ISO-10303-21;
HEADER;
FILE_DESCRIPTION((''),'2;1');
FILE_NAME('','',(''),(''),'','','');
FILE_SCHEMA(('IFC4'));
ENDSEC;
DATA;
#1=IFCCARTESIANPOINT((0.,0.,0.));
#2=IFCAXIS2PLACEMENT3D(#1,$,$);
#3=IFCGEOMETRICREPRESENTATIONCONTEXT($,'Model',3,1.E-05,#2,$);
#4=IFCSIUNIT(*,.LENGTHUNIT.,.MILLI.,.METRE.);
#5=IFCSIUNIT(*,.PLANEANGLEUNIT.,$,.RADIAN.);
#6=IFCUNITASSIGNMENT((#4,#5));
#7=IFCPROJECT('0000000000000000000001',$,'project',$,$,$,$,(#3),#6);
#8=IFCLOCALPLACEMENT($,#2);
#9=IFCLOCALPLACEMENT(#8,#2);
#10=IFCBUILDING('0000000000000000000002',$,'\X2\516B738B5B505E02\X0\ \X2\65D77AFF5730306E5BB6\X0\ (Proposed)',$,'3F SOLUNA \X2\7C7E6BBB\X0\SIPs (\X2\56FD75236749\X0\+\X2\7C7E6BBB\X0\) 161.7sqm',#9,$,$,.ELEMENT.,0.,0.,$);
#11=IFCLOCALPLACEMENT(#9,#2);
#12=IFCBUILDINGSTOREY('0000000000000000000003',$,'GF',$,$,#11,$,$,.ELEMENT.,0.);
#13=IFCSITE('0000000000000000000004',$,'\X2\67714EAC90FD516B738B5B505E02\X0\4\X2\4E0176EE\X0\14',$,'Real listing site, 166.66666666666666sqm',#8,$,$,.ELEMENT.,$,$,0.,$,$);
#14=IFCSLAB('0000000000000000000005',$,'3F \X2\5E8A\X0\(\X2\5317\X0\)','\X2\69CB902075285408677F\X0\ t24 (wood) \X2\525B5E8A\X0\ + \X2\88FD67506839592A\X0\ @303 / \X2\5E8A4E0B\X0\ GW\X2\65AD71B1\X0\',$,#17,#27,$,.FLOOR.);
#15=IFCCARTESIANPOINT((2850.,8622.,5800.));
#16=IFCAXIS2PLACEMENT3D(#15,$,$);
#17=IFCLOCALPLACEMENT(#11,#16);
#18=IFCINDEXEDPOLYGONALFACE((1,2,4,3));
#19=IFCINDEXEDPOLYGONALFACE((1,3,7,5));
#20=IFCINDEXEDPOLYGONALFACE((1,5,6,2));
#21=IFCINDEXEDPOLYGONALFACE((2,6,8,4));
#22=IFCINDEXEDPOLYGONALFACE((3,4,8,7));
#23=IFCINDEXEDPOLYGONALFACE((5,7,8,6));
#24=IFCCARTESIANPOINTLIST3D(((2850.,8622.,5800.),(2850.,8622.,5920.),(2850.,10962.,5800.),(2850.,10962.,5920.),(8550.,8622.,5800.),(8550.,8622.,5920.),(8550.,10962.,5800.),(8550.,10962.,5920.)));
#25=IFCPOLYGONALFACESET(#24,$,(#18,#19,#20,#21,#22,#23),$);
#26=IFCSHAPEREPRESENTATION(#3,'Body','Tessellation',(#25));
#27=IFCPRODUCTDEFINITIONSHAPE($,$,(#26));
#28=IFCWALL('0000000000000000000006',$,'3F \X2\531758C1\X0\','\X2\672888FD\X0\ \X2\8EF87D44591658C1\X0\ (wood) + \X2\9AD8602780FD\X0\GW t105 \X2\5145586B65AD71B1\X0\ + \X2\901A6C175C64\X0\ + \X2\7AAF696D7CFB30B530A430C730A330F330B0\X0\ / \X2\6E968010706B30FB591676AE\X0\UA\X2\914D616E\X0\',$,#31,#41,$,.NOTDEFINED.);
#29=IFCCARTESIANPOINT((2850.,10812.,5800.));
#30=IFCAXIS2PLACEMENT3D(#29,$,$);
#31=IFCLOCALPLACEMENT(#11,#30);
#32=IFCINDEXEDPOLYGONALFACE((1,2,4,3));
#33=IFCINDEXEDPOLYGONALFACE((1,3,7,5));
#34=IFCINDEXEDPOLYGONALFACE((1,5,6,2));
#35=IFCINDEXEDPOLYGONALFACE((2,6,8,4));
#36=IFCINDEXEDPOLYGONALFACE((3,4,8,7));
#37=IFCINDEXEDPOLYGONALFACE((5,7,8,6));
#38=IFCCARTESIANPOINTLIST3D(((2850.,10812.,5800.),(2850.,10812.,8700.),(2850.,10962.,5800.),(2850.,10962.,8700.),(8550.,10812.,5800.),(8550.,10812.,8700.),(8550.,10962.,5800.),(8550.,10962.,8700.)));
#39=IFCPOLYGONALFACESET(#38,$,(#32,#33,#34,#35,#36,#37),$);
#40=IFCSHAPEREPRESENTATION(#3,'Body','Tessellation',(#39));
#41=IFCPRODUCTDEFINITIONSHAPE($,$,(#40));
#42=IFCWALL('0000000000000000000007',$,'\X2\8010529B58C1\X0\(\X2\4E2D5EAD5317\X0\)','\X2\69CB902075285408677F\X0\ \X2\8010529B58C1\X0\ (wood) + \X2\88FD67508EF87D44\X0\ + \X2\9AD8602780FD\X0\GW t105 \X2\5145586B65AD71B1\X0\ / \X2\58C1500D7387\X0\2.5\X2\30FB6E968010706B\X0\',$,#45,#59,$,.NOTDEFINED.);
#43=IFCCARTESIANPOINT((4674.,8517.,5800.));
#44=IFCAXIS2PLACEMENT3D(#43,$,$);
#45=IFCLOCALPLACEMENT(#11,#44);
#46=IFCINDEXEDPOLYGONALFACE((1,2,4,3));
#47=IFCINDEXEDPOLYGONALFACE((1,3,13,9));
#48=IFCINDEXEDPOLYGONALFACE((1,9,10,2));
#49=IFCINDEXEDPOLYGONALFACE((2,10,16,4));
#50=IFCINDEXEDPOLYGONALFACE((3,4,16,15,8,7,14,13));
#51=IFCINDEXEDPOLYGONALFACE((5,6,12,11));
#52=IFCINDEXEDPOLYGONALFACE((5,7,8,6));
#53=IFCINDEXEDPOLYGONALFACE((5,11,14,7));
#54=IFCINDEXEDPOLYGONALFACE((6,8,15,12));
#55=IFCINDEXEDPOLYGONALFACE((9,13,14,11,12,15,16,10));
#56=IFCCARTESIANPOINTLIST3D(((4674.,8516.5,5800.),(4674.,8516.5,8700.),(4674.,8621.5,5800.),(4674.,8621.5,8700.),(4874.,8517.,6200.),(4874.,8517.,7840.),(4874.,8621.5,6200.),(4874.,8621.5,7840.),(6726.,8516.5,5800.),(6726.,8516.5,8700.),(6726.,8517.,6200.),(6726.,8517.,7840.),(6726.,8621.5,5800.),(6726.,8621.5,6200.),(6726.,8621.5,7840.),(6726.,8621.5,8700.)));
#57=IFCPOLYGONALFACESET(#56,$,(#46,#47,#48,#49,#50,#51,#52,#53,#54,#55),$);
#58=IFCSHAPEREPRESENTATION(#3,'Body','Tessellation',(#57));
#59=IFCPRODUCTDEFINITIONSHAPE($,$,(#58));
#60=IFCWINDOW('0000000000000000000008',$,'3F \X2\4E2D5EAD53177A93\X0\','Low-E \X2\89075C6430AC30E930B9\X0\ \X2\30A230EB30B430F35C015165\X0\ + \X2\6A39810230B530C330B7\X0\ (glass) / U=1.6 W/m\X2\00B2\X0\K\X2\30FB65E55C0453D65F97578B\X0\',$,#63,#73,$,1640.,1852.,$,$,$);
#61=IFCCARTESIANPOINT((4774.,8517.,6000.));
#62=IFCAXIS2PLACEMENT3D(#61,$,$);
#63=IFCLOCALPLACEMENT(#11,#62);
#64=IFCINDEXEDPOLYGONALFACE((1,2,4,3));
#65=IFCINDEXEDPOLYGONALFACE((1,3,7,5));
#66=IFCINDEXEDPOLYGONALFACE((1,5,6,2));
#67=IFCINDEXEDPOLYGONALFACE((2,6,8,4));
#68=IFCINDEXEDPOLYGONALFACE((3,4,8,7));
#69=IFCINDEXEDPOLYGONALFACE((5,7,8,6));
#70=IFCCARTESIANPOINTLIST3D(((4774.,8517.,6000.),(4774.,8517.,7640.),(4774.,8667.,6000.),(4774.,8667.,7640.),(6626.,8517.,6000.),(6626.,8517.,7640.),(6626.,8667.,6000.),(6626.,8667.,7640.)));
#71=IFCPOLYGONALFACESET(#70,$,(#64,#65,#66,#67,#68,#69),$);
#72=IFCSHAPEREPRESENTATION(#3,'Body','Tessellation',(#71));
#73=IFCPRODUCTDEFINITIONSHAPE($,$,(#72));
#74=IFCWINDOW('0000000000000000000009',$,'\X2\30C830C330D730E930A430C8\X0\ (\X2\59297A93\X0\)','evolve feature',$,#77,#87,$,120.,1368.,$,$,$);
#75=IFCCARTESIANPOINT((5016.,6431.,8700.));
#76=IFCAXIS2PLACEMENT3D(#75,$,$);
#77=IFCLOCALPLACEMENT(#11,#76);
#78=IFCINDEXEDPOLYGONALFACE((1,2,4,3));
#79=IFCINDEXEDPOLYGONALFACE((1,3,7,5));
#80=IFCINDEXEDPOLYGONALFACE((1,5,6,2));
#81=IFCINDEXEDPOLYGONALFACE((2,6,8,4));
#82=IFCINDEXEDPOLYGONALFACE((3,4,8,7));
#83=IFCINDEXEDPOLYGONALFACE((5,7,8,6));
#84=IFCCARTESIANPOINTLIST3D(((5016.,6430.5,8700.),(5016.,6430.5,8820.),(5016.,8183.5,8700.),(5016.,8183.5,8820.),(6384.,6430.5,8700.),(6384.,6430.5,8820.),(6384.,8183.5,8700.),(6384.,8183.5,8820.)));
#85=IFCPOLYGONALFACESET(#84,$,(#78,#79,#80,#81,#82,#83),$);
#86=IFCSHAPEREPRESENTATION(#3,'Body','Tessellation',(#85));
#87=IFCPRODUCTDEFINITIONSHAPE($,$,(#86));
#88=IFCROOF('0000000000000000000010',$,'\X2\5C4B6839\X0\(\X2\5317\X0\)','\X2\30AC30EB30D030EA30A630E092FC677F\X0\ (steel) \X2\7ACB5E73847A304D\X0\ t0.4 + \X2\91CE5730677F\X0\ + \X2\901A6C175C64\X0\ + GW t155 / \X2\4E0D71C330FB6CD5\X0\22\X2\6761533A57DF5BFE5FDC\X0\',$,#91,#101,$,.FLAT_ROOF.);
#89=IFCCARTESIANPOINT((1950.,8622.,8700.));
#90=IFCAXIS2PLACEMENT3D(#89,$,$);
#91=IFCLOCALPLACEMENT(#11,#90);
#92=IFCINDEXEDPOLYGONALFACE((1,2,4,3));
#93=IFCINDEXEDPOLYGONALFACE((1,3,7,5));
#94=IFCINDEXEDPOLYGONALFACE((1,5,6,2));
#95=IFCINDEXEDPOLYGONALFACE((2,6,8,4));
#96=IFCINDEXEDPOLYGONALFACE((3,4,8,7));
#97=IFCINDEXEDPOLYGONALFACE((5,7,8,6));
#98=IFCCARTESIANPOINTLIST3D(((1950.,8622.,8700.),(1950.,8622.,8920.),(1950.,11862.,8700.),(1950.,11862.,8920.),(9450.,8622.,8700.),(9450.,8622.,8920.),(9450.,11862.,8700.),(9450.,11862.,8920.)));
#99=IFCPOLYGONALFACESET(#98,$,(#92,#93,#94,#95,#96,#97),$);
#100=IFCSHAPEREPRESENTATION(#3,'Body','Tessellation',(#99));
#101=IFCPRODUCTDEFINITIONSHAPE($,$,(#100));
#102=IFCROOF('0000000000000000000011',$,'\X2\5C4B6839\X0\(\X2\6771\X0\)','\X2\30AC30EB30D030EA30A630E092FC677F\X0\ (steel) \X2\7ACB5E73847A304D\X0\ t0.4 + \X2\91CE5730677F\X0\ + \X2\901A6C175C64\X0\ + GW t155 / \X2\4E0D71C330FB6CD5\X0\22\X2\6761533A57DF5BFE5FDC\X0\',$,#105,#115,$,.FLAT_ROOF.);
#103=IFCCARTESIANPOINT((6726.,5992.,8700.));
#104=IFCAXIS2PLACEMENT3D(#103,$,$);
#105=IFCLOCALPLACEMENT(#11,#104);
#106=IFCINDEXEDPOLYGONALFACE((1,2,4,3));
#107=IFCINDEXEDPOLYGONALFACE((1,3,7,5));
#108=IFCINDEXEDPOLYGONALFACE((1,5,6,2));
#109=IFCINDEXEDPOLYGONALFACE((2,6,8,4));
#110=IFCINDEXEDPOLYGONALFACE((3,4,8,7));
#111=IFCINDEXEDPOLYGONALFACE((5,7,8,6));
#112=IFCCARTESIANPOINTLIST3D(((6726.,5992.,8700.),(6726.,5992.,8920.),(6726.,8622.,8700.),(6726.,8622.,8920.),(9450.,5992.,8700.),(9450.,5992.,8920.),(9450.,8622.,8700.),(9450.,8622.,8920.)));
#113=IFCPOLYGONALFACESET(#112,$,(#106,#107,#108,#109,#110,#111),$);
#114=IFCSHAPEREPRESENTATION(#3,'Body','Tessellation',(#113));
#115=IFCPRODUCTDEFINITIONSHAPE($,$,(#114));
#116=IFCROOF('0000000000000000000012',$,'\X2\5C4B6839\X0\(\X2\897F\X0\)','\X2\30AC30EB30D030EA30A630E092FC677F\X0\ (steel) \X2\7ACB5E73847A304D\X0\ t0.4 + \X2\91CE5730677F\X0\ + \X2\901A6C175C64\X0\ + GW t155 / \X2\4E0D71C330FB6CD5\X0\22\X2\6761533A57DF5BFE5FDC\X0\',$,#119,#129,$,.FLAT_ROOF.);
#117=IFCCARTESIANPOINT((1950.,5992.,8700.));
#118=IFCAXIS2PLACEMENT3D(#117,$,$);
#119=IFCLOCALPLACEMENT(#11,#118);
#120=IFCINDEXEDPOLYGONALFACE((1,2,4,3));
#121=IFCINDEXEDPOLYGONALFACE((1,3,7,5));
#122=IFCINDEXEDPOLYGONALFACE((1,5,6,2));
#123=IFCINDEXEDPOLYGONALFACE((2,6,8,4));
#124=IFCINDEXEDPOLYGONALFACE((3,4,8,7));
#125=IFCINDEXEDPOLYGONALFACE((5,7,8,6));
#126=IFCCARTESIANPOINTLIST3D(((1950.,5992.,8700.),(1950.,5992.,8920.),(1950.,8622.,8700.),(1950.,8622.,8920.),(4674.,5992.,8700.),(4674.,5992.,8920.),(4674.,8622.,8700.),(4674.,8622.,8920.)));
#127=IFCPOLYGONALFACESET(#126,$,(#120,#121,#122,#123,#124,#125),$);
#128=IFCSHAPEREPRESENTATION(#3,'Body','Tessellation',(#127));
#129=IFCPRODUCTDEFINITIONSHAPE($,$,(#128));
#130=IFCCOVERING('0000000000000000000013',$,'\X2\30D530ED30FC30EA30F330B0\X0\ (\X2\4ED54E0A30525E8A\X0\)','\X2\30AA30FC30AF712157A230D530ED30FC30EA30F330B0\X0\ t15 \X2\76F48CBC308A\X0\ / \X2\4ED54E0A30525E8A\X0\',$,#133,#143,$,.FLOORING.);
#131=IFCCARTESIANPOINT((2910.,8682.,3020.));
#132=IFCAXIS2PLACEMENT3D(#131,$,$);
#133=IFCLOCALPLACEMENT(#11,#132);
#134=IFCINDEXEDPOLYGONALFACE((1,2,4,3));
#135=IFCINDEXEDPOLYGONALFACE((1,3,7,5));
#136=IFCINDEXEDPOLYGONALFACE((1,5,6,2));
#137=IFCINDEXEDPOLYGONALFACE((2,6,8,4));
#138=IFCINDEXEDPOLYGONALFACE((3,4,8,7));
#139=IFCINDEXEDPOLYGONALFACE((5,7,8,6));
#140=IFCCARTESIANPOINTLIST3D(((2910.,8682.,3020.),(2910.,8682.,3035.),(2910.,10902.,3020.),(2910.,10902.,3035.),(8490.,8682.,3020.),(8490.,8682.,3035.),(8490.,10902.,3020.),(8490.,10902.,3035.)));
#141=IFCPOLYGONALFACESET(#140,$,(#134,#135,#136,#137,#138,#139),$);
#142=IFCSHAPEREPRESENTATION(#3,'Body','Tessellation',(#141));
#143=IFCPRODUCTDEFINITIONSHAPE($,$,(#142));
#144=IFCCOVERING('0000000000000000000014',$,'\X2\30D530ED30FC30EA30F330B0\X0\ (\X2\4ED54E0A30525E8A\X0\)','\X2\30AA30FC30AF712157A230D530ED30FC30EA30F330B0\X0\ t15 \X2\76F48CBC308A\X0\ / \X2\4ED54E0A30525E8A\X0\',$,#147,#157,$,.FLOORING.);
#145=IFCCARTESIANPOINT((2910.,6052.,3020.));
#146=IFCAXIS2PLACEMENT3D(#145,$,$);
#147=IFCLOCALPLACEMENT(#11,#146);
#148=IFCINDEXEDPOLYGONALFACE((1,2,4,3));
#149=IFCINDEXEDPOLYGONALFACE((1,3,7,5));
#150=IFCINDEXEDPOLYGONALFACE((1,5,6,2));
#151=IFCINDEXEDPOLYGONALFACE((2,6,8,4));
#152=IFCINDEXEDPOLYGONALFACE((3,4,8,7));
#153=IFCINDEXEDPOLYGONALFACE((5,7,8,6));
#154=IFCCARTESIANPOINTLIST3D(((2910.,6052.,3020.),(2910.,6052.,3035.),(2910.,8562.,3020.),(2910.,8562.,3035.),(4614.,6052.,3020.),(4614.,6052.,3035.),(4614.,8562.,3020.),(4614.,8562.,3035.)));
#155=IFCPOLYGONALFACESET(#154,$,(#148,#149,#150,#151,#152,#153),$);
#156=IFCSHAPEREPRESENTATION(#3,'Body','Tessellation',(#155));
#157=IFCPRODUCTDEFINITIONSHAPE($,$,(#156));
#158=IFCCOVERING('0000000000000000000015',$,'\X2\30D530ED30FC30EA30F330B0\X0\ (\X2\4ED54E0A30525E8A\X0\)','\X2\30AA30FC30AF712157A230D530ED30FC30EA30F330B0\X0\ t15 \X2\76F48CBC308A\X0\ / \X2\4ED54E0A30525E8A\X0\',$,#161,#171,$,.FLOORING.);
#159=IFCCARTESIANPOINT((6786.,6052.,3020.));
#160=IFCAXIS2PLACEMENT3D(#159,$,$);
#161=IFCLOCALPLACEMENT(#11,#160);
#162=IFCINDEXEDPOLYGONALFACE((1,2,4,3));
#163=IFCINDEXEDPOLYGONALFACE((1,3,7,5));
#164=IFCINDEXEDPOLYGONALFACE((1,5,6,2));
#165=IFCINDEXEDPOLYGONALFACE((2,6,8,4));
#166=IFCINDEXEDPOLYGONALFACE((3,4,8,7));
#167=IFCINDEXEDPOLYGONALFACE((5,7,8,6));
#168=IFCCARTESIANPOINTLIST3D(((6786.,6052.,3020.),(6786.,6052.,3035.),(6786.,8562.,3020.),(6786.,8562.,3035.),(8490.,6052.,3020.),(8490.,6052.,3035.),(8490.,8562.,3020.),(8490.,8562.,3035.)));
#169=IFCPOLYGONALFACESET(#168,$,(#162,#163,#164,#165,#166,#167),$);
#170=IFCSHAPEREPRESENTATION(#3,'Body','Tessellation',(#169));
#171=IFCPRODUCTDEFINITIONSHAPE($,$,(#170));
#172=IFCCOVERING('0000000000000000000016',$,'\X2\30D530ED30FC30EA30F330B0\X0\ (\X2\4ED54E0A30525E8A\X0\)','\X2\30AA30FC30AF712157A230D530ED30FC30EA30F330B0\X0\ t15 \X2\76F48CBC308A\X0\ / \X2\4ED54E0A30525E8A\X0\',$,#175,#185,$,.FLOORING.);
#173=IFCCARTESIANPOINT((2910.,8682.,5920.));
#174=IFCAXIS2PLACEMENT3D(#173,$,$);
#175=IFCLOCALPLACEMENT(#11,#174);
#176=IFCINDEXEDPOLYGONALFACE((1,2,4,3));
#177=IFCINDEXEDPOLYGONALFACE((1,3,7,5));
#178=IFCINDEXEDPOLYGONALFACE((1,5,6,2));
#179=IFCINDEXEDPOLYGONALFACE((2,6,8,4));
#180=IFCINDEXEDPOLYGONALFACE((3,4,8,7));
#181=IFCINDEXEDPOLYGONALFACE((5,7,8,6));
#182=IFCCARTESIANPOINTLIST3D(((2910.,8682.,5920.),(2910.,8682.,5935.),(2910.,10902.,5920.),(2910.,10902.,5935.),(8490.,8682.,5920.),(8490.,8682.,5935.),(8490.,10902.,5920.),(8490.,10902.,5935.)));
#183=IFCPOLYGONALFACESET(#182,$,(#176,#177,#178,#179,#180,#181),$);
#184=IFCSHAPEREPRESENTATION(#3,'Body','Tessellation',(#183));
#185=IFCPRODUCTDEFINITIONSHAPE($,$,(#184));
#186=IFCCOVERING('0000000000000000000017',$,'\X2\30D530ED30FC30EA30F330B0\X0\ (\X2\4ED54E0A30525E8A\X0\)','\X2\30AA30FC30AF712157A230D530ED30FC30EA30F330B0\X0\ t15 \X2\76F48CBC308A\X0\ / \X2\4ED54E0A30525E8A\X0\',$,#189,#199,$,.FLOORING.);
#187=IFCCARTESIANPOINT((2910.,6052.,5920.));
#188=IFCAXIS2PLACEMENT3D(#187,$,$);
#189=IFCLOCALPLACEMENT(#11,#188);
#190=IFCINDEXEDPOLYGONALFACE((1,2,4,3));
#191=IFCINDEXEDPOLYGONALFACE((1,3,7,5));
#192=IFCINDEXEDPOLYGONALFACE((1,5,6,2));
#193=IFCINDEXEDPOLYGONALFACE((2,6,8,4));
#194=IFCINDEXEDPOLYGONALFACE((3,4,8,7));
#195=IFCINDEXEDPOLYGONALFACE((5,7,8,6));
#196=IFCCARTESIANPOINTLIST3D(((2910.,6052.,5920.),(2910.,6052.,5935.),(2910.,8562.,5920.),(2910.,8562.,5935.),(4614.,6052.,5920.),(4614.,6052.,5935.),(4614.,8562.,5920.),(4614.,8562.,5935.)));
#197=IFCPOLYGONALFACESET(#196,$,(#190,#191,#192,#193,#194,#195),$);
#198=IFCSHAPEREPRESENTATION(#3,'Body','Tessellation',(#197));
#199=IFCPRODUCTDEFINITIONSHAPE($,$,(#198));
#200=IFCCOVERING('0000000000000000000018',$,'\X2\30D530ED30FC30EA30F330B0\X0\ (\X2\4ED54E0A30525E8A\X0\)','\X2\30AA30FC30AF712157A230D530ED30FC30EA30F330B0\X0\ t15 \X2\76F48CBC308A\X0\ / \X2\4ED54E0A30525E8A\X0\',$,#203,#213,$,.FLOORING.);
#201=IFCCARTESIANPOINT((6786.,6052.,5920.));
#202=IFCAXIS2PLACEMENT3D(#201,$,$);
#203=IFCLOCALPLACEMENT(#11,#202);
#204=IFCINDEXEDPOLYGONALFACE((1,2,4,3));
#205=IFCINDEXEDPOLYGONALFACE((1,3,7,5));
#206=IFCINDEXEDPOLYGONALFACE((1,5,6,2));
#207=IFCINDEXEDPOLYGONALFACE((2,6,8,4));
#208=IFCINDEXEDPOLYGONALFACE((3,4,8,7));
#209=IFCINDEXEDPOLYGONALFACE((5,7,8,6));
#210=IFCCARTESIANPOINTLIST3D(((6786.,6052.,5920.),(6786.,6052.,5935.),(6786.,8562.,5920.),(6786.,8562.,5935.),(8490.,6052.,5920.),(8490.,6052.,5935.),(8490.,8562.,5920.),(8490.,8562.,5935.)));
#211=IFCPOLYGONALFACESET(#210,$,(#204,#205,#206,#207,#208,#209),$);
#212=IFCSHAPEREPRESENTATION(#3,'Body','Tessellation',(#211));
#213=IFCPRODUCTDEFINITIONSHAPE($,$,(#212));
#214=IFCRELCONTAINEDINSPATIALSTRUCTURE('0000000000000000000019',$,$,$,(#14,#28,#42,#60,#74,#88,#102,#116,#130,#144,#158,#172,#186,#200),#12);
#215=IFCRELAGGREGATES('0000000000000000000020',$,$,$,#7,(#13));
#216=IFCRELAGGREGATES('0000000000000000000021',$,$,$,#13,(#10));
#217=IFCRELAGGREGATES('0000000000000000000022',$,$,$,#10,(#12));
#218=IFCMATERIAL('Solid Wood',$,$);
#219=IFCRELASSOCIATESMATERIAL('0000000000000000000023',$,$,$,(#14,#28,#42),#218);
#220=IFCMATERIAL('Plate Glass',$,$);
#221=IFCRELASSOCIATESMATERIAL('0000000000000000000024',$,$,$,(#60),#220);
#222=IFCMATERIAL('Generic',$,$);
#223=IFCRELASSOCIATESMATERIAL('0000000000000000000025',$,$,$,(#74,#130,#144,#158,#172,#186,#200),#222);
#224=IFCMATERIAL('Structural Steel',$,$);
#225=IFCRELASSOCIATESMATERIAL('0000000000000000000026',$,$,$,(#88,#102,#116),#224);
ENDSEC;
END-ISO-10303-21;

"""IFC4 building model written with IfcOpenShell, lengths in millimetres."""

from ifc_helpers import new_model, si_unit, frame, frame_2d, origin, place, context, project, spatial, rectangle, extrude, material, element, fill, save


model = new_model("IFC4")

# Units and contexts
model_context = context("Model", 3, precision=1e-05, world=origin())
ifc_project = project(units=[si_unit("LENGTHUNIT", "METRE", prefix="MILLI"), si_unit("PLANEANGLEUNIT", "RADIAN")], contexts=[model_context])

# Site, building, storey
site_placement = place(None, origin())
site = spatial("IfcSite", under=ifc_project, at=site_placement, Name="東京都八王子市4丁目14", ObjectType="Real listing site, 166.66666666666666sqm", CompositionType="ELEMENT", RefElevation=0.0)
building_placement = place(site_placement, origin())
building = spatial("IfcBuilding", under=site, at=building_placement, Name="八王子市 旗竿地の家 (Proposed)", ObjectType="3F SOLUNA 籾殻SIPs (国産杉+籾殻) 161.7sqm", CompositionType="ELEMENT", ElevationOfRefHeight=0.0, ElevationOfTerrain=0.0)
storey_placement = place(building_placement, origin())
storey = spatial("IfcBuildingStorey", under=building, at=storey_placement, Name="GF", CompositionType="ELEMENT", Elevation=0.0)

# Slab
ifc_material_1 = material(Name="Solid Wood")
slab_placement = place(storey_placement, frame((2850.0, 8622.0, 5800.0)))
element("IfcSlab", 1, at=slab_placement, inside=storey, material=ifc_material_1, Name="3F 床(北)", Description="構造用合板 t24 (wood) 剛床 + 製材根太 @303 / 床下 GW断熱", PredefinedType="FLOOR", context=model_context, shape_type="SweptSolid", body=[
    extrude(rectangle(XDim=5700.0, YDim=2340.0, at=frame_2d((2850.0, 1170.0))), frame((2850.0, 8622.0, 5800.0)), (0.0, 0.0, 1.0), 120.0),
])

# Wall
wall_1_placement = place(storey_placement, frame((2850.0, 10812.0, 5800.0)))
element("IfcWall", 2, at=wall_1_placement, inside=storey, material=ifc_material_1, Name="3F 北壁", Description="木製 軸組外壁 (wood) + 高性能GW t105 充填断熱 + 通気層 + 窯業系サイディング / 準耐火・外皮UA配慮", PredefinedType="NOTDEFINED", context=model_context, shape_type="SweptSolid", body=[
    extrude(rectangle(XDim=5700.0, YDim=150.0, at=frame_2d((2850.0, 75.0))), frame((2850.0, 10812.0, 5800.0)), (0.0, 0.0, 1.0), 2900.0),
])

# Wall, opening, window
wall_2_placement = place(storey_placement, frame((4674.0, 8517.0, 5800.0)))
wall_2 = element("IfcWall", 3, at=wall_2_placement, inside=storey, material=ifc_material_1, Name="耐力壁(中庭北)", Description="構造用合板 耐力壁 (wood) + 製材軸組 + 高性能GW t105 充填断熱 / 壁倍率2.5・準耐火", PredefinedType="NOTDEFINED", context=model_context, shape_type="SweptSolid", body=[
    extrude(rectangle(XDim=2052.0, YDim=105.0, at=frame_2d((1026.0, 52.0))), frame((4674.0, 8517.0, 5800.0)), (0.0, 0.0, 1.0), 2900.0),
])
opening_placement = place(storey_placement, frame((4774.0, 8517.0, 6000.0)))
opening = element("IfcOpeningElement", 4, at=opening_placement, cuts=wall_2, PredefinedType="NOTDEFINED", context=model_context, shape_type="SweptSolid", body=[
    extrude(rectangle(XDim=1852.0, YDim=150.0, at=frame_2d((926.0, 75.0))), frame((4774.0, 8517.0, 6000.0)), (0.0, 0.0, 1.0), 1640.0),
])
ifc_material_2 = material(Name="Plate Glass")
window_1_placement = place(storey_placement, frame((4774.0, 8517.0, 6000.0)))
window_1 = element("IfcWindow", 5, at=window_1_placement, inside=storey, material=ifc_material_2, Name="3F 中庭北窓", Description="Low-E 複層ガラス アルゴン封入 + 樹脂サッシ (glass) / U=1.6 W/m²K・日射取得型", OverallHeight=1640.0, OverallWidth=1852.0, context=model_context, shape_type="SweptSolid", body=[
    extrude(rectangle(XDim=1852.0, YDim=150.0, at=frame_2d((926.0, 75.0))), frame((4774.0, 8517.0, 6000.0)), (0.0, 0.0, 1.0), 1640.0),
])
fill(opening, window_1)

# Window
ifc_material_3 = material(Name="Generic")
window_2_placement = place(storey_placement, frame((5016.0, 6431.0, 8700.0)))
element("IfcWindow", 6, at=window_2_placement, inside=storey, material=ifc_material_3, Name="トップライト (天窓)", Description="evolve feature", OverallHeight=120.0, OverallWidth=1368.0, context=model_context, shape_type="SweptSolid", body=[
    extrude(rectangle(XDim=1368.0, YDim=1753.0, at=frame_2d((684.0, 876.0))), frame((5016.0, 6431.0, 8700.0)), (0.0, 0.0, 1.0), 120.0),
])

# Roofs
ifc_material_4 = material(Name="Structural Steel")
roof_1_placement = place(storey_placement, frame((1950.0, 8622.0, 8700.0)))
element("IfcRoof", 7, at=roof_1_placement, inside=storey, material=ifc_material_4, Name="屋根(北)", Description="ガルバリウム鋼板 (steel) 立平葺き t0.4 + 野地板 + 通気層 + GW t155 / 不燃・法22条区域対応", PredefinedType="FLAT_ROOF", context=model_context, shape_type="SweptSolid", body=[
    extrude(rectangle(XDim=7500.0, YDim=3240.0, at=frame_2d((3750.0, 1620.0))), frame((1950.0, 8622.0, 8700.0)), (0.0, 0.0, 1.0), 220.0),
])
roof_2_placement = place(storey_placement, frame((6726.0, 5992.0, 8700.0)))
element("IfcRoof", 8, at=roof_2_placement, inside=storey, material=ifc_material_4, Name="屋根(東)", Description="ガルバリウム鋼板 (steel) 立平葺き t0.4 + 野地板 + 通気層 + GW t155 / 不燃・法22条区域対応", PredefinedType="FLAT_ROOF", context=model_context, shape_type="SweptSolid", body=[
    extrude(rectangle(XDim=2724.0, YDim=2630.0, at=frame_2d((1362.0, 1315.0))), frame((6726.0, 5992.0, 8700.0)), (0.0, 0.0, 1.0), 220.0),
])
roof_3_placement = place(storey_placement, frame((1950.0, 5992.0, 8700.0)))
element("IfcRoof", 9, at=roof_3_placement, inside=storey, material=ifc_material_4, Name="屋根(西)", Description="ガルバリウム鋼板 (steel) 立平葺き t0.4 + 野地板 + 通気層 + GW t155 / 不燃・法22条区域対応", PredefinedType="FLAT_ROOF", context=model_context, shape_type="SweptSolid", body=[
    extrude(rectangle(XDim=2724.0, YDim=2630.0, at=frame_2d((1362.0, 1315.0))), frame((1950.0, 5992.0, 8700.0)), (0.0, 0.0, 1.0), 220.0),
])

# Coverings
covering_1_placement = place(storey_placement, frame((2910.0, 8682.0, 3020.0)))
element("IfcCovering", 10, at=covering_1_placement, inside=storey, material=ifc_material_3, Name="フローリング (仕上げ床)", Description="オーク無垢フローリング t15 直貼り / 仕上げ床", PredefinedType="FLOORING", context=model_context, shape_type="SweptSolid", body=[
    extrude(rectangle(XDim=5580.0, YDim=2220.0, at=frame_2d((2790.0, 1110.0))), frame((2910.0, 8682.0, 3020.0)), (0.0, 0.0, 1.0), 15.0),
])
covering_2_placement = place(storey_placement, frame((2910.0, 6052.0, 3020.0)))
element("IfcCovering", 11, at=covering_2_placement, inside=storey, material=ifc_material_3, Name="フローリング (仕上げ床)", Description="オーク無垢フローリング t15 直貼り / 仕上げ床", PredefinedType="FLOORING", context=model_context, shape_type="SweptSolid", body=[
    extrude(rectangle(XDim=1704.0, YDim=2510.0, at=frame_2d((852.0, 1255.0))), frame((2910.0, 6052.0, 3020.0)), (0.0, 0.0, 1.0), 15.0),
])
covering_3_placement = place(storey_placement, frame((6786.0, 6052.0, 3020.0)))
element("IfcCovering", 12, at=covering_3_placement, inside=storey, material=ifc_material_3, Name="フローリング (仕上げ床)", Description="オーク無垢フローリング t15 直貼り / 仕上げ床", PredefinedType="FLOORING", context=model_context, shape_type="SweptSolid", body=[
    extrude(rectangle(XDim=1704.0, YDim=2510.0, at=frame_2d((852.0, 1255.0))), frame((6786.0, 6052.0, 3020.0)), (0.0, 0.0, 1.0), 15.0),
])
covering_4_placement = place(storey_placement, frame((2910.0, 8682.0, 5920.0)))
element("IfcCovering", 13, at=covering_4_placement, inside=storey, material=ifc_material_3, Name="フローリング (仕上げ床)", Description="オーク無垢フローリング t15 直貼り / 仕上げ床", PredefinedType="FLOORING", context=model_context, shape_type="SweptSolid", body=[
    extrude(rectangle(XDim=5580.0, YDim=2220.0, at=frame_2d((2790.0, 1110.0))), frame((2910.0, 8682.0, 5920.0)), (0.0, 0.0, 1.0), 15.0),
])
covering_5_placement = place(storey_placement, frame((2910.0, 6052.0, 5920.0)))
element("IfcCovering", 14, at=covering_5_placement, inside=storey, material=ifc_material_3, Name="フローリング (仕上げ床)", Description="オーク無垢フローリング t15 直貼り / 仕上げ床", PredefinedType="FLOORING", context=model_context, shape_type="SweptSolid", body=[
    extrude(rectangle(XDim=1704.0, YDim=2510.0, at=frame_2d((852.0, 1255.0))), frame((2910.0, 6052.0, 5920.0)), (0.0, 0.0, 1.0), 15.0),
])
covering_6_placement = place(storey_placement, frame((6786.0, 6052.0, 5920.0)))
element("IfcCovering", 15, at=covering_6_placement, inside=storey, material=ifc_material_3, Name="フローリング (仕上げ床)", Description="オーク無垢フローリング t15 直貼り / 仕上げ床", PredefinedType="FLOORING", context=model_context, shape_type="SweptSolid", body=[
    extrude(rectangle(XDim=1704.0, YDim=2510.0, at=frame_2d((852.0, 1255.0))), frame((6786.0, 6052.0, 5920.0)), (0.0, 0.0, 1.0), 15.0),
])

save(model, "model.ifc")
